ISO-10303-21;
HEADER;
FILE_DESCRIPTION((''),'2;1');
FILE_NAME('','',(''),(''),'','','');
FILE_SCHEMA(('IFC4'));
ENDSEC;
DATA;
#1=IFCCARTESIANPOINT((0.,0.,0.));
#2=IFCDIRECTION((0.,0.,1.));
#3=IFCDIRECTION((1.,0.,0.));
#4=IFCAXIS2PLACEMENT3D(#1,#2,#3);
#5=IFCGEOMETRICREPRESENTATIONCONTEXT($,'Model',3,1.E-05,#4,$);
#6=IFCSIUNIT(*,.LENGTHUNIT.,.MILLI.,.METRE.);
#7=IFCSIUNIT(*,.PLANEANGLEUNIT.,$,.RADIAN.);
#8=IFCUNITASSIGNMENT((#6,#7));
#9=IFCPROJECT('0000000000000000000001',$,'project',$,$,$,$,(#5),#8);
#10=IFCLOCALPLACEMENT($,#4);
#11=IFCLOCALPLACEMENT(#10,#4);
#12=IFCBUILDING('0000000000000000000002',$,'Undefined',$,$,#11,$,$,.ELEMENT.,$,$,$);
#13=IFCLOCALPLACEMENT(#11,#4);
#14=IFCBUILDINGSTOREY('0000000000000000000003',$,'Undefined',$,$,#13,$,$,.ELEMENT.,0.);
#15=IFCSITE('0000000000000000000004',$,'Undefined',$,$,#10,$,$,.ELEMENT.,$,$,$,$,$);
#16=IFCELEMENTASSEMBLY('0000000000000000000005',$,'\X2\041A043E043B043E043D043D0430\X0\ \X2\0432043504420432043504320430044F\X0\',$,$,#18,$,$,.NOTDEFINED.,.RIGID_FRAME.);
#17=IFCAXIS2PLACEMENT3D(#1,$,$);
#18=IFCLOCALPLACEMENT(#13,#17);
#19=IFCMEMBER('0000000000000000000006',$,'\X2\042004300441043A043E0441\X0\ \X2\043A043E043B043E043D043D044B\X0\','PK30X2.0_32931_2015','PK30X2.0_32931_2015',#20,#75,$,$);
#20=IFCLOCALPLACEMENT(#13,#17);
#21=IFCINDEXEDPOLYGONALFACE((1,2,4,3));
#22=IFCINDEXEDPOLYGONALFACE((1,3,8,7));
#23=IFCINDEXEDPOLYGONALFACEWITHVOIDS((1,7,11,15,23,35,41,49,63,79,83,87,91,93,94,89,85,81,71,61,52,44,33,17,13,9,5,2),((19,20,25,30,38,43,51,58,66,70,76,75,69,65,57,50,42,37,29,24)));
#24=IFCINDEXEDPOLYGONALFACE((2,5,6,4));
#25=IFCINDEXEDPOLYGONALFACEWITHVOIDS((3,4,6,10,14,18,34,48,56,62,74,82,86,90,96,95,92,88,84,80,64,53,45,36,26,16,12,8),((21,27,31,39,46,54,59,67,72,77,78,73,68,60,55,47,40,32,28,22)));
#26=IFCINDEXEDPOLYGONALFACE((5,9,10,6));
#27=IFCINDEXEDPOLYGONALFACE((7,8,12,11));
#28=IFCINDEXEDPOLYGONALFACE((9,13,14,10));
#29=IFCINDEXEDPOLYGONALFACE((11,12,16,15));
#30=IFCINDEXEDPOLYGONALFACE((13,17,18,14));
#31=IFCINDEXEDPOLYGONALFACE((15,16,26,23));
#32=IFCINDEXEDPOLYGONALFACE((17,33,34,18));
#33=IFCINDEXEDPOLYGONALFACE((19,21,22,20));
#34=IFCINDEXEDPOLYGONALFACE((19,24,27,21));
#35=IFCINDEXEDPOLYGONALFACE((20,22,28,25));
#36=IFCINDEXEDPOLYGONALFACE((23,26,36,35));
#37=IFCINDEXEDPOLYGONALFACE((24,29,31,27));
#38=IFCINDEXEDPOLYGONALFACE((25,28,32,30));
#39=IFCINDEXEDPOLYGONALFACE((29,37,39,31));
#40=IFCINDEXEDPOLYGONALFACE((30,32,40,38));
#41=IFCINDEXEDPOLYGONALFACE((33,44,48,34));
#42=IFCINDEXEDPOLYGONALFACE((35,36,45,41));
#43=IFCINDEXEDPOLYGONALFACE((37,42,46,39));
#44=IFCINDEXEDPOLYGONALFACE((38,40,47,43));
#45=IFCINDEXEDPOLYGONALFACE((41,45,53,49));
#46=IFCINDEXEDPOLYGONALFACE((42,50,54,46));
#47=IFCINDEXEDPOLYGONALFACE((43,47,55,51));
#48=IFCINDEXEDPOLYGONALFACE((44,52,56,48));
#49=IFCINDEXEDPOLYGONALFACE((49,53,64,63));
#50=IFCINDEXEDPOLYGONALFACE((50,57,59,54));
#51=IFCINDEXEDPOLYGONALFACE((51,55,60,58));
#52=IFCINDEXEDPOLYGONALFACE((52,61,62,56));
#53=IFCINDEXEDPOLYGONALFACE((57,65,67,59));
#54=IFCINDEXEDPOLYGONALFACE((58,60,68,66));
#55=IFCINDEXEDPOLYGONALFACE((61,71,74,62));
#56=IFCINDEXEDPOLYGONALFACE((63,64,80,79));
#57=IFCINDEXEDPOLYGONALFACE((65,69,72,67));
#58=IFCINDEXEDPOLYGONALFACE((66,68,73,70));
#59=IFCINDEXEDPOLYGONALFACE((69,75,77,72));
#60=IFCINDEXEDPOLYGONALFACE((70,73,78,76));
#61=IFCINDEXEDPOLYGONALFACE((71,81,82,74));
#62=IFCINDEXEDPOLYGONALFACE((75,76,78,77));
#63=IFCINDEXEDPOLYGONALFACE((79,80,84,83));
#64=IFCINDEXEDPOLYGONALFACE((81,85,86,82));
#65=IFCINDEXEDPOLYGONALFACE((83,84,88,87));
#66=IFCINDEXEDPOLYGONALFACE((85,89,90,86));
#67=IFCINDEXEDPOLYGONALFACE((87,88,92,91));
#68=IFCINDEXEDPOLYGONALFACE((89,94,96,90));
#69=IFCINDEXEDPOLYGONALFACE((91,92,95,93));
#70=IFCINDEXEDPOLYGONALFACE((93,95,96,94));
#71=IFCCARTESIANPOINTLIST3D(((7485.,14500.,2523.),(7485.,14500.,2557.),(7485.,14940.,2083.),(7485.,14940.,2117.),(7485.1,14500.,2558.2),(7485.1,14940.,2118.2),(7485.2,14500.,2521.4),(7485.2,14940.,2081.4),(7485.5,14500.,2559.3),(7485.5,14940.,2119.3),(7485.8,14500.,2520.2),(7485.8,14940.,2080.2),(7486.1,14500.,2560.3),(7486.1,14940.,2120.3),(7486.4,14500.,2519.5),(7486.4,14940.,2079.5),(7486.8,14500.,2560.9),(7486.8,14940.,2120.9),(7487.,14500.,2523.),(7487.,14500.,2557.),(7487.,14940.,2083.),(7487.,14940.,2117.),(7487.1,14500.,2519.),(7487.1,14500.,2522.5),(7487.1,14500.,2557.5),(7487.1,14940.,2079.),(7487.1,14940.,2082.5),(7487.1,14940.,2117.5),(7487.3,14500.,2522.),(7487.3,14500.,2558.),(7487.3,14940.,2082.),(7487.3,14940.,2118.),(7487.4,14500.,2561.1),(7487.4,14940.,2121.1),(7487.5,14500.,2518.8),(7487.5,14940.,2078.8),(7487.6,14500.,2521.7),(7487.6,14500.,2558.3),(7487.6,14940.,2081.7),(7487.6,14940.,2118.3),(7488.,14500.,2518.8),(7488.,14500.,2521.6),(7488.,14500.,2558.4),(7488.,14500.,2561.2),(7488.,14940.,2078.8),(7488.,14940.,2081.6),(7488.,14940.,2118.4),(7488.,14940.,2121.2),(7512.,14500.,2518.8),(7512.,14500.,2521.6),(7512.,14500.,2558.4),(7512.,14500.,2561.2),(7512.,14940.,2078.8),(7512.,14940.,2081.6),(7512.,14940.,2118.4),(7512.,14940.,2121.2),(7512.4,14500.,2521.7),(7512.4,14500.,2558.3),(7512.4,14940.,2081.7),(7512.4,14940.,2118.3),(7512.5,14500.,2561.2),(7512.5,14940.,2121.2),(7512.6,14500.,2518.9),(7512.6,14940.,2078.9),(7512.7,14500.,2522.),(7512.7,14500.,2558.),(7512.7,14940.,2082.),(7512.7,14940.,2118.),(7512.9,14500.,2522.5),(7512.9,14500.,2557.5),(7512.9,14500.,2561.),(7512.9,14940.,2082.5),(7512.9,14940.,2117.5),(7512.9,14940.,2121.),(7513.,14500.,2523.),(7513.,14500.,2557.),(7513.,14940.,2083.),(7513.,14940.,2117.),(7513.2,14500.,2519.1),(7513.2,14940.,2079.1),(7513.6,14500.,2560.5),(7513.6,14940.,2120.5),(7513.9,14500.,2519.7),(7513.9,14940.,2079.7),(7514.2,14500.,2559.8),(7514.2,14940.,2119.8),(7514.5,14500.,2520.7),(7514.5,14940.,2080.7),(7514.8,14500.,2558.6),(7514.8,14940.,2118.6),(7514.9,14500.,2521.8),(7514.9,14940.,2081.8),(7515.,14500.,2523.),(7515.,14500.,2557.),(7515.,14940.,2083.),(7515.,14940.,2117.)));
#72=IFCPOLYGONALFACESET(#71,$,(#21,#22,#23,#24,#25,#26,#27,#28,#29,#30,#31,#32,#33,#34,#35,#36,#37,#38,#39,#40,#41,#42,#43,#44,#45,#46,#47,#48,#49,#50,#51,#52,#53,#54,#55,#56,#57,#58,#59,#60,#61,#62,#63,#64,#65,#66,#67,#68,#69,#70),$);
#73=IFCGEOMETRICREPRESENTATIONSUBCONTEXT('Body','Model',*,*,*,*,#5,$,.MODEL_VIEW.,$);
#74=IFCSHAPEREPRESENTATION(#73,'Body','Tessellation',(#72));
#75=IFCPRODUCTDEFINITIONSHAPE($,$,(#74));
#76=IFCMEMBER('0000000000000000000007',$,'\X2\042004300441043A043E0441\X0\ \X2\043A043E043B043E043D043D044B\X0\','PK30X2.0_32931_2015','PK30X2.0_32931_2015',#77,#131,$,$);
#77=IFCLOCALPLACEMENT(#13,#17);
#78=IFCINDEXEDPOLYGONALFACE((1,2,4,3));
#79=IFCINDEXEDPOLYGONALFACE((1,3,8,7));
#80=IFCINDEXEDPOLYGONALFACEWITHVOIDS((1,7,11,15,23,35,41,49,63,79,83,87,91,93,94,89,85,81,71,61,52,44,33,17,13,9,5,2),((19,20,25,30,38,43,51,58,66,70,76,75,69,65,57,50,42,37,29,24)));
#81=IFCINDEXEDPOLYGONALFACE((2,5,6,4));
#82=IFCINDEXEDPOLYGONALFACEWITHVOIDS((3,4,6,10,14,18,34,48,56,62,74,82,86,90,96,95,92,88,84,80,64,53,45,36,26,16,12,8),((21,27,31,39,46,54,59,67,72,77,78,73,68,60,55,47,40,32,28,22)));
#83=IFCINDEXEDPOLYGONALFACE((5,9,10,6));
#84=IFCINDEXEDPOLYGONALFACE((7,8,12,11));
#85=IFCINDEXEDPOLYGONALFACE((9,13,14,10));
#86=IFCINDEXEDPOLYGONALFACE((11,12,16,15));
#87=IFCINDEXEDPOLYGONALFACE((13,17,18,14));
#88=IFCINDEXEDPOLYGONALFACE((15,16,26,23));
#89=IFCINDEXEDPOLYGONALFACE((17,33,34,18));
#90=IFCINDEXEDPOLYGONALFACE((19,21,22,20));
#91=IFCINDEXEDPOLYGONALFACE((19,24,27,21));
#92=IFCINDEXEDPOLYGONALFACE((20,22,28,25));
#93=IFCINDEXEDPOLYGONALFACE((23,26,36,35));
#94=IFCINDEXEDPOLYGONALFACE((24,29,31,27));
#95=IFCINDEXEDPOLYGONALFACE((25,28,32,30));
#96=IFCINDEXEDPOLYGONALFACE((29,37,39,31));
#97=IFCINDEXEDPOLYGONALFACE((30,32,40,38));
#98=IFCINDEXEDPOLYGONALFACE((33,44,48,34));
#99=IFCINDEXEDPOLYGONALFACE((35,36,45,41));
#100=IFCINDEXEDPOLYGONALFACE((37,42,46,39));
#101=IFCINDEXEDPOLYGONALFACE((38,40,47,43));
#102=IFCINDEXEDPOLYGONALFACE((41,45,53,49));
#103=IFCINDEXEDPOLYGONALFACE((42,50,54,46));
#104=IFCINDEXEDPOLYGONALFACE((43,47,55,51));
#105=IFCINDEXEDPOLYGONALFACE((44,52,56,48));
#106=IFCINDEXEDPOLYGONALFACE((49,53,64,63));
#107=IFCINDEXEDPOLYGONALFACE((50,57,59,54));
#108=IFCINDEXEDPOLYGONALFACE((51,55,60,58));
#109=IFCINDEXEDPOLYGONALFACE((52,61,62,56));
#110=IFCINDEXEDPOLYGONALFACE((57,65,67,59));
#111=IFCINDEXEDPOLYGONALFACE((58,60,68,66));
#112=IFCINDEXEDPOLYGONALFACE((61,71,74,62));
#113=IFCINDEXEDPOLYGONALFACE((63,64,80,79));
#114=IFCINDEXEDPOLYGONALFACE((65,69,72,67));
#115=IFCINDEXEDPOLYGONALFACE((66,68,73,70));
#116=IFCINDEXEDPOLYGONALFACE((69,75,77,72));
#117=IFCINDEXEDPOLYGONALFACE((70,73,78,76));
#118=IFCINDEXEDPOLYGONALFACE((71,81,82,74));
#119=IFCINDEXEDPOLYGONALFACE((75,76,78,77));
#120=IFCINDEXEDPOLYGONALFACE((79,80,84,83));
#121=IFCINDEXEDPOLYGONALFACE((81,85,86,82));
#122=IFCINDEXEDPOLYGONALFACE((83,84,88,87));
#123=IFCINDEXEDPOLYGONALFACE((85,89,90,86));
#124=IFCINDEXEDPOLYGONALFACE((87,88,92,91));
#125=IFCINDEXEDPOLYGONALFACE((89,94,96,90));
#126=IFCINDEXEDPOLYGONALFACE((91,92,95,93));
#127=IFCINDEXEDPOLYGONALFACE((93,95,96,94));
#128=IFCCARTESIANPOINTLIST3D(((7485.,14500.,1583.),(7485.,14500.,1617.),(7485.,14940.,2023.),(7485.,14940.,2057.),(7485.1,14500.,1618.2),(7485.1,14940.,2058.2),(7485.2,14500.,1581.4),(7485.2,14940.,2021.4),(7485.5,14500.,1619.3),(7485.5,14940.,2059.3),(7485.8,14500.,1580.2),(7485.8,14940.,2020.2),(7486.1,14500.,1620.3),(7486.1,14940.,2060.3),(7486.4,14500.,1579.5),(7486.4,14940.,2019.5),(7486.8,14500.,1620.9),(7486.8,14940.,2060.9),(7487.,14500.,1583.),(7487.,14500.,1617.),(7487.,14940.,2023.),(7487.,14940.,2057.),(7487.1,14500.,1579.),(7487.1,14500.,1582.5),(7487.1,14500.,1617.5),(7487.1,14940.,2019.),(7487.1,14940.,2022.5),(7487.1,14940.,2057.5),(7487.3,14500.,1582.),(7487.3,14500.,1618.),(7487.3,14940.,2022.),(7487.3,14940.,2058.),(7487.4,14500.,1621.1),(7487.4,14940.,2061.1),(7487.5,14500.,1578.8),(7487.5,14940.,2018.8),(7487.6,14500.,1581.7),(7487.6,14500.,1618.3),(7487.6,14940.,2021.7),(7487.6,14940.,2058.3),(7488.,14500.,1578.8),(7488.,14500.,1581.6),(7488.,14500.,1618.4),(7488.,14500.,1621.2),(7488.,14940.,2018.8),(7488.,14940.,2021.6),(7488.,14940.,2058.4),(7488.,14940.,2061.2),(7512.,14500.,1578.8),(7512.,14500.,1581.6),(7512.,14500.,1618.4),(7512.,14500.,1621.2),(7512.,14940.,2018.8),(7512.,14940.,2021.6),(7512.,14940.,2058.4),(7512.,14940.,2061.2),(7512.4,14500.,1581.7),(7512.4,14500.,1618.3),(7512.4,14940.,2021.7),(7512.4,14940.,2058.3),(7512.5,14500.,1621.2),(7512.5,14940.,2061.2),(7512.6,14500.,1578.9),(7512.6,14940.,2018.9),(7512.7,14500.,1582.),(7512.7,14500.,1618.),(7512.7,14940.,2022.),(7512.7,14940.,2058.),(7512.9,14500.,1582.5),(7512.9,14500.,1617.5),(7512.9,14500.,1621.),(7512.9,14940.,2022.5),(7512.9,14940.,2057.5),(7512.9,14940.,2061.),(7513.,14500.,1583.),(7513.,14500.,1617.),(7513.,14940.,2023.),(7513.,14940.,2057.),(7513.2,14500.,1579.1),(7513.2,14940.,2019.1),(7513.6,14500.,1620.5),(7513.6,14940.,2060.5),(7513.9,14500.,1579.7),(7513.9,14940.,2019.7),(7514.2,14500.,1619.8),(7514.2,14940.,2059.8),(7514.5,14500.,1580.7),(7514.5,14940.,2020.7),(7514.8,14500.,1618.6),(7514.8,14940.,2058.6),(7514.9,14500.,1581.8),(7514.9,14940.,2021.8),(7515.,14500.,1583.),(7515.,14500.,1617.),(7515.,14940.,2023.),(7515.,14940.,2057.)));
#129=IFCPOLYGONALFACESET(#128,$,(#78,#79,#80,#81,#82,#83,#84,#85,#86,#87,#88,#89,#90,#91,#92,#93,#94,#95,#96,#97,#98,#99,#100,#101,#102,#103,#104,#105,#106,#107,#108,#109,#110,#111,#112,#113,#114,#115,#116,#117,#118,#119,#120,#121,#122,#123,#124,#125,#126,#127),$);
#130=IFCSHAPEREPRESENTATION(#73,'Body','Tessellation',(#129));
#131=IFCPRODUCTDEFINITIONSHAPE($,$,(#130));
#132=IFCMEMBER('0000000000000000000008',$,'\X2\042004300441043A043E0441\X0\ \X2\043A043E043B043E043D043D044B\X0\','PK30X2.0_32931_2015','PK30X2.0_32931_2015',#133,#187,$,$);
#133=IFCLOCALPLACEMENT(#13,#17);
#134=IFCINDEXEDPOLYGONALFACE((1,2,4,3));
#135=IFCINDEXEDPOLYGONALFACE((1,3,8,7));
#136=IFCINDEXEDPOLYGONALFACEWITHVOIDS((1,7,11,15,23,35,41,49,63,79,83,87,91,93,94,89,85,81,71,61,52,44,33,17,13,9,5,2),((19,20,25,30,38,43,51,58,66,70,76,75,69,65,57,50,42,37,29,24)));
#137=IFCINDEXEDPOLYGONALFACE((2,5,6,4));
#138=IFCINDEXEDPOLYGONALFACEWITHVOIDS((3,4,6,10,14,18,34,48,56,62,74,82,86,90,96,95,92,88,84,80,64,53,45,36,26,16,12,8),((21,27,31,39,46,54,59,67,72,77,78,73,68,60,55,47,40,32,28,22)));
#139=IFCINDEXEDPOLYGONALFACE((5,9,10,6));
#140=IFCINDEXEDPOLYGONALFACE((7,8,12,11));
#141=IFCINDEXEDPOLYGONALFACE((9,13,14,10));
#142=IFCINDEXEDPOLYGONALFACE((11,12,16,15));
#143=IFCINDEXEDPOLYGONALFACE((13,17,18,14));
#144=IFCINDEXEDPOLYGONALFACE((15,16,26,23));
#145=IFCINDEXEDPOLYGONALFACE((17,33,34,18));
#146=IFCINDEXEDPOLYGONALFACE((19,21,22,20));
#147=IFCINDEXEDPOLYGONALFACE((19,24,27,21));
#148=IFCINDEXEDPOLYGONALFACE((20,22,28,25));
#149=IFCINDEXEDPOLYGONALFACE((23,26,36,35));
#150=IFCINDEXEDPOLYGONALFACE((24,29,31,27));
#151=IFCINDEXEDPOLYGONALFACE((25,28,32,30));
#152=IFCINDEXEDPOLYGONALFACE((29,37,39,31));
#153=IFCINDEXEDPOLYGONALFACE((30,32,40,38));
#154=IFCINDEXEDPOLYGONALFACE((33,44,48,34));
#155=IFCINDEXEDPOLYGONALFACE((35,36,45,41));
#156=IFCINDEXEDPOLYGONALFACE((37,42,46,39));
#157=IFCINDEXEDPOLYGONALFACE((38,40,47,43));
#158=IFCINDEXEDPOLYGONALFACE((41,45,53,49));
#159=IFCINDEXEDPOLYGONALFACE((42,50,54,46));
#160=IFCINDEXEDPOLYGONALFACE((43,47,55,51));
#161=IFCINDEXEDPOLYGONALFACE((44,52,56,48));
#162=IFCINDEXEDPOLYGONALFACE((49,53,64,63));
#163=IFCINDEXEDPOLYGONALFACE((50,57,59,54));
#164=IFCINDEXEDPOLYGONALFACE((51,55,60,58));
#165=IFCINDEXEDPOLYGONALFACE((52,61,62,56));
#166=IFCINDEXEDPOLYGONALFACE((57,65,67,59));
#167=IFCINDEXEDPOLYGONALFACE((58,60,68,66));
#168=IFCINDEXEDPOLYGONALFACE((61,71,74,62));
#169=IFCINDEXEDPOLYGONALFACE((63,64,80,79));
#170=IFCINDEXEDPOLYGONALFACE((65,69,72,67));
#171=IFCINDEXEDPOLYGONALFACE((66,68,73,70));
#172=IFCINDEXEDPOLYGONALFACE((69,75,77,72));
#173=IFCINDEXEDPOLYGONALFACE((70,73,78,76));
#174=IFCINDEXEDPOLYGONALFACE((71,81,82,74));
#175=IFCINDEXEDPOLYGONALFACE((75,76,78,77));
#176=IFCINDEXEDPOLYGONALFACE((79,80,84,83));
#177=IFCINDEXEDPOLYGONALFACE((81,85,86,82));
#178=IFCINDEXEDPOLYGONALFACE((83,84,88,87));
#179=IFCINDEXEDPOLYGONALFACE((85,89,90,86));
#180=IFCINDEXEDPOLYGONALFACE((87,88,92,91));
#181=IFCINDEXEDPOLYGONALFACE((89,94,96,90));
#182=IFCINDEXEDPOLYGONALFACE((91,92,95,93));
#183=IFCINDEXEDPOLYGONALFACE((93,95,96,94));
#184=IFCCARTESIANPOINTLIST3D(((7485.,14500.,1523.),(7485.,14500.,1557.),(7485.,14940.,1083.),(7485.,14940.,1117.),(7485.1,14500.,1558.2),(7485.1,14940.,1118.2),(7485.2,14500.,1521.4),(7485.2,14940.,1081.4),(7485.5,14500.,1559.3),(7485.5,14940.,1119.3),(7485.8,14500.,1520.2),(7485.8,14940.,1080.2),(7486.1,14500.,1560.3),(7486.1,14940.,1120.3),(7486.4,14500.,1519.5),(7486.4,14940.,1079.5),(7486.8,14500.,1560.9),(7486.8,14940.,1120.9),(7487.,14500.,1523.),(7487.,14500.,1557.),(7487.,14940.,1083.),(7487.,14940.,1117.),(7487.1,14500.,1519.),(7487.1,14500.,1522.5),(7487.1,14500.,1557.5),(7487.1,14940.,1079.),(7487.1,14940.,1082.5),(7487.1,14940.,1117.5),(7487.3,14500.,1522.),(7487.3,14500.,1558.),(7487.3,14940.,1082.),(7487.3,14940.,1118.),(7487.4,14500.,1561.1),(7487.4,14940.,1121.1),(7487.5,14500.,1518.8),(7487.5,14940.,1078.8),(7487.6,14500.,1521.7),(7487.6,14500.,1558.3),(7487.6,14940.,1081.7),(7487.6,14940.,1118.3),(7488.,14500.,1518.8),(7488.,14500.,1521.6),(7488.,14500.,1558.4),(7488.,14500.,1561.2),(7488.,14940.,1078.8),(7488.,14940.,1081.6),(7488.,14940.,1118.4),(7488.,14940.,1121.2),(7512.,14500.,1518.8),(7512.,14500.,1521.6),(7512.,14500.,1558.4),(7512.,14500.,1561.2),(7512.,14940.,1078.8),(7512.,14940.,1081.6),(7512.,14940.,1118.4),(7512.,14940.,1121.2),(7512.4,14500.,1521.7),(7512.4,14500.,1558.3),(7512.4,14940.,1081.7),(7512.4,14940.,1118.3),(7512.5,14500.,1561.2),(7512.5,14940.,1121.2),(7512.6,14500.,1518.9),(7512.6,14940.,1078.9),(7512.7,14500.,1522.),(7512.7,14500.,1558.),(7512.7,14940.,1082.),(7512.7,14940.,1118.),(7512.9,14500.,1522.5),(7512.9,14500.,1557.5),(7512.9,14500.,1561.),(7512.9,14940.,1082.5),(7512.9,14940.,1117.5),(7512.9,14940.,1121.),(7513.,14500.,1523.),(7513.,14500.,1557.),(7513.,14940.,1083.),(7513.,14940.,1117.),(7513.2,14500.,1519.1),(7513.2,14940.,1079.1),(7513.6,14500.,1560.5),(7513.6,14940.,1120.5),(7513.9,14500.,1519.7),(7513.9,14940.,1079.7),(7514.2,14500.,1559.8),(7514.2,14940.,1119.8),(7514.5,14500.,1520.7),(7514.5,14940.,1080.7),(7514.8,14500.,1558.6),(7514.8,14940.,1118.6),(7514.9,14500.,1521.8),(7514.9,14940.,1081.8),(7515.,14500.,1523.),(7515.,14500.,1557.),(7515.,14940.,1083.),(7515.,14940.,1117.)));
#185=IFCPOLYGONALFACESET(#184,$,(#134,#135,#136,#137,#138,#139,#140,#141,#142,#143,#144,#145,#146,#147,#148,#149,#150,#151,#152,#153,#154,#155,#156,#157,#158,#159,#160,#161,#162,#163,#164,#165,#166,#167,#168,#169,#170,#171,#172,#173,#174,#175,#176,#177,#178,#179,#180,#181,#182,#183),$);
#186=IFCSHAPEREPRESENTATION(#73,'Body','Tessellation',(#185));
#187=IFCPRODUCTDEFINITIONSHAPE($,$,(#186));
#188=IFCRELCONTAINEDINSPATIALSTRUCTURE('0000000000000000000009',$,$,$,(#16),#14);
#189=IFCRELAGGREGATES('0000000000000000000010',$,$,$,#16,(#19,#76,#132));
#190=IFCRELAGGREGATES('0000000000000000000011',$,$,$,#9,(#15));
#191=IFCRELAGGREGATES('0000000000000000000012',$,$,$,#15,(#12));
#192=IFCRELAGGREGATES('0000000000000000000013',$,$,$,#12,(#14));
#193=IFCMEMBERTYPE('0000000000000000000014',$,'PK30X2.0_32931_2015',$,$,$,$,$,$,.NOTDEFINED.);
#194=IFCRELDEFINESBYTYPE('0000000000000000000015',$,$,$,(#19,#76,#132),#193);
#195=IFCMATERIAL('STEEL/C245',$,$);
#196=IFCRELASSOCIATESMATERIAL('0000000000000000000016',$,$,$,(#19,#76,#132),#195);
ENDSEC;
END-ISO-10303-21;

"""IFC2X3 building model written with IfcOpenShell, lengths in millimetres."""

from ifc_helpers import new_model, si_unit, frame, origin_with_axes, origin_2d_with_axis, place, context, subcontext, project, spatial, hollow_rectangle, extrude, clip, halfspace, material, type_object, element, aggregate, save


model = new_model("IFC2X3")

# Units and contexts
model_context = context("Model", 3, precision=1e-05, world=origin_with_axes())
body_context = subcontext(model_context, "Body", "Model", "MODEL_VIEW")
ifc_project = project(units=[si_unit("LENGTHUNIT", "METRE", prefix="MILLI"), si_unit("PLANEANGLEUNIT", "RADIAN")], contexts=[model_context])

# Site, building, storey
site_placement = place(None, origin_with_axes())
site = spatial("IfcSite", under=ifc_project, at=site_placement, Name="Undefined", CompositionType="ELEMENT")
building_placement = place(site_placement, origin_with_axes())
building = spatial("IfcBuilding", under=site, at=building_placement, Name="Undefined", CompositionType="ELEMENT")
storey_placement = place(building_placement, origin_with_axes())
storey = spatial("IfcBuildingStorey", under=building, at=storey_placement, Name="Undefined", CompositionType="ELEMENT", Elevation=0.0)

# Shared definitions
ifc_material_1 = material(Name="STEEL/C245")

# Element assembly
assembly_1_placement = place(storey_placement, origin_with_axes())
assembly_1 = element("IfcElementAssembly", 1, at=assembly_1_placement, inside=storey, Name="Колонна ветвевая", AssemblyPlace="NOTDEFINED", PredefinedType="RIGID_FRAME")

# Members
member_type_1 = type_object("IfcMemberType", Name="PK30X2.0_32931_2015", PredefinedType="NOTDEFINED")
member_1_placement = place(assembly_1_placement, frame((7500.0, 14470.0, 2570.0), z_axis=(0.0, -0.707107, -0.707107), x_axis=(0.0, 0.707107, -0.707107)))
member_1 = element("IfcMember", 2, at=member_1_placement, type_object=member_type_1, material=ifc_material_1, Name="Раскос колонны", Description="PK30X2.0_32931_2015", ObjectType="PK30X2.0_32931_2015", context=body_context, shape_type="Clipping", body=[
    clip(clip(extrude(hollow_rectangle(XDim=30.0, YDim=30.0, WallThickness=2.0, InnerFilletRadius=1.0, OuterFilletRadius=3.0, at=origin_2d_with_axis()), frame((695.0, 0.0, 0.0), z_axis=(-1.0, 0.0, 0.0), x_axis=(0.0, -1.0, 0.0)), (0.0, 0.0, 1.0), 682.9), halfspace(frame((629.0, 0.0, -35.7), z_axis=(-0.707107, 0.0, 0.707107), x_axis=(0.707107, 0.0, 0.707107)), True)), halfspace(frame((65.2, 0.0, 22.8), z_axis=(-0.707107, 0.0, 0.707107), x_axis=(0.707107, 0.0, 0.707107)), False)),
])
member_2_placement = place(assembly_1_placement, frame((7500.0, 14470.0, 1570.0), z_axis=(0.0, -0.707107, 0.707107), x_axis=(0.0, 0.707107, 0.707107)))
member_2 = element("IfcMember", 3, at=member_2_placement, type_object=member_type_1, material=ifc_material_1, Name="Раскос колонны", Description="PK30X2.0_32931_2015", ObjectType="PK30X2.0_32931_2015", context=body_context, shape_type="Clipping", body=[
    clip(clip(extrude(hollow_rectangle(XDim=30.0, YDim=30.0, WallThickness=2.0, InnerFilletRadius=1.0, OuterFilletRadius=3.0, at=origin_2d_with_axis()), frame((695.0, 0.0, 0.0), z_axis=(-1.0, 0.0, 0.0), x_axis=(0.0, -1.0, 0.0)), (0.0, 0.0, 1.0), 682.9), halfspace(frame((629.0, 0.0, -35.7), z_axis=(-0.707107, 0.0, 0.707107), x_axis=(0.707107, 0.0, 0.707107)), True)), halfspace(frame((65.2, 0.0, 22.8), z_axis=(-0.707107, 0.0, 0.707107), x_axis=(0.707107, 0.0, 0.707107)), False)),
])
member_3_placement = place(assembly_1_placement, frame((7500.0, 14470.0, 1570.0), z_axis=(0.0, -0.707107, -0.707107), x_axis=(0.0, 0.707107, -0.707107)))
member_3 = element("IfcMember", 4, at=member_3_placement, type_object=member_type_1, material=ifc_material_1, Name="Раскос колонны", Description="PK30X2.0_32931_2015", ObjectType="PK30X2.0_32931_2015", context=body_context, shape_type="Clipping", body=[
    clip(clip(extrude(hollow_rectangle(XDim=30.0, YDim=30.0, WallThickness=2.0, InnerFilletRadius=1.0, OuterFilletRadius=3.0, at=origin_2d_with_axis()), frame((695.0, 0.0, 0.0), z_axis=(-1.0, 0.0, 0.0), x_axis=(0.0, -1.0, 0.0)), (0.0, 0.0, 1.0), 682.9), halfspace(frame((629.0, 0.0, -35.7), z_axis=(-0.707107, 0.0, 0.707107), x_axis=(0.707107, 0.0, 0.707107)), True)), halfspace(frame((65.2, 0.0, 22.8), z_axis=(-0.707107, 0.0, 0.707107), x_axis=(0.707107, 0.0, 0.707107)), False)),
])

aggregate(assembly_1, [member_1, member_2, member_3])

save(model, "model.ifc")
